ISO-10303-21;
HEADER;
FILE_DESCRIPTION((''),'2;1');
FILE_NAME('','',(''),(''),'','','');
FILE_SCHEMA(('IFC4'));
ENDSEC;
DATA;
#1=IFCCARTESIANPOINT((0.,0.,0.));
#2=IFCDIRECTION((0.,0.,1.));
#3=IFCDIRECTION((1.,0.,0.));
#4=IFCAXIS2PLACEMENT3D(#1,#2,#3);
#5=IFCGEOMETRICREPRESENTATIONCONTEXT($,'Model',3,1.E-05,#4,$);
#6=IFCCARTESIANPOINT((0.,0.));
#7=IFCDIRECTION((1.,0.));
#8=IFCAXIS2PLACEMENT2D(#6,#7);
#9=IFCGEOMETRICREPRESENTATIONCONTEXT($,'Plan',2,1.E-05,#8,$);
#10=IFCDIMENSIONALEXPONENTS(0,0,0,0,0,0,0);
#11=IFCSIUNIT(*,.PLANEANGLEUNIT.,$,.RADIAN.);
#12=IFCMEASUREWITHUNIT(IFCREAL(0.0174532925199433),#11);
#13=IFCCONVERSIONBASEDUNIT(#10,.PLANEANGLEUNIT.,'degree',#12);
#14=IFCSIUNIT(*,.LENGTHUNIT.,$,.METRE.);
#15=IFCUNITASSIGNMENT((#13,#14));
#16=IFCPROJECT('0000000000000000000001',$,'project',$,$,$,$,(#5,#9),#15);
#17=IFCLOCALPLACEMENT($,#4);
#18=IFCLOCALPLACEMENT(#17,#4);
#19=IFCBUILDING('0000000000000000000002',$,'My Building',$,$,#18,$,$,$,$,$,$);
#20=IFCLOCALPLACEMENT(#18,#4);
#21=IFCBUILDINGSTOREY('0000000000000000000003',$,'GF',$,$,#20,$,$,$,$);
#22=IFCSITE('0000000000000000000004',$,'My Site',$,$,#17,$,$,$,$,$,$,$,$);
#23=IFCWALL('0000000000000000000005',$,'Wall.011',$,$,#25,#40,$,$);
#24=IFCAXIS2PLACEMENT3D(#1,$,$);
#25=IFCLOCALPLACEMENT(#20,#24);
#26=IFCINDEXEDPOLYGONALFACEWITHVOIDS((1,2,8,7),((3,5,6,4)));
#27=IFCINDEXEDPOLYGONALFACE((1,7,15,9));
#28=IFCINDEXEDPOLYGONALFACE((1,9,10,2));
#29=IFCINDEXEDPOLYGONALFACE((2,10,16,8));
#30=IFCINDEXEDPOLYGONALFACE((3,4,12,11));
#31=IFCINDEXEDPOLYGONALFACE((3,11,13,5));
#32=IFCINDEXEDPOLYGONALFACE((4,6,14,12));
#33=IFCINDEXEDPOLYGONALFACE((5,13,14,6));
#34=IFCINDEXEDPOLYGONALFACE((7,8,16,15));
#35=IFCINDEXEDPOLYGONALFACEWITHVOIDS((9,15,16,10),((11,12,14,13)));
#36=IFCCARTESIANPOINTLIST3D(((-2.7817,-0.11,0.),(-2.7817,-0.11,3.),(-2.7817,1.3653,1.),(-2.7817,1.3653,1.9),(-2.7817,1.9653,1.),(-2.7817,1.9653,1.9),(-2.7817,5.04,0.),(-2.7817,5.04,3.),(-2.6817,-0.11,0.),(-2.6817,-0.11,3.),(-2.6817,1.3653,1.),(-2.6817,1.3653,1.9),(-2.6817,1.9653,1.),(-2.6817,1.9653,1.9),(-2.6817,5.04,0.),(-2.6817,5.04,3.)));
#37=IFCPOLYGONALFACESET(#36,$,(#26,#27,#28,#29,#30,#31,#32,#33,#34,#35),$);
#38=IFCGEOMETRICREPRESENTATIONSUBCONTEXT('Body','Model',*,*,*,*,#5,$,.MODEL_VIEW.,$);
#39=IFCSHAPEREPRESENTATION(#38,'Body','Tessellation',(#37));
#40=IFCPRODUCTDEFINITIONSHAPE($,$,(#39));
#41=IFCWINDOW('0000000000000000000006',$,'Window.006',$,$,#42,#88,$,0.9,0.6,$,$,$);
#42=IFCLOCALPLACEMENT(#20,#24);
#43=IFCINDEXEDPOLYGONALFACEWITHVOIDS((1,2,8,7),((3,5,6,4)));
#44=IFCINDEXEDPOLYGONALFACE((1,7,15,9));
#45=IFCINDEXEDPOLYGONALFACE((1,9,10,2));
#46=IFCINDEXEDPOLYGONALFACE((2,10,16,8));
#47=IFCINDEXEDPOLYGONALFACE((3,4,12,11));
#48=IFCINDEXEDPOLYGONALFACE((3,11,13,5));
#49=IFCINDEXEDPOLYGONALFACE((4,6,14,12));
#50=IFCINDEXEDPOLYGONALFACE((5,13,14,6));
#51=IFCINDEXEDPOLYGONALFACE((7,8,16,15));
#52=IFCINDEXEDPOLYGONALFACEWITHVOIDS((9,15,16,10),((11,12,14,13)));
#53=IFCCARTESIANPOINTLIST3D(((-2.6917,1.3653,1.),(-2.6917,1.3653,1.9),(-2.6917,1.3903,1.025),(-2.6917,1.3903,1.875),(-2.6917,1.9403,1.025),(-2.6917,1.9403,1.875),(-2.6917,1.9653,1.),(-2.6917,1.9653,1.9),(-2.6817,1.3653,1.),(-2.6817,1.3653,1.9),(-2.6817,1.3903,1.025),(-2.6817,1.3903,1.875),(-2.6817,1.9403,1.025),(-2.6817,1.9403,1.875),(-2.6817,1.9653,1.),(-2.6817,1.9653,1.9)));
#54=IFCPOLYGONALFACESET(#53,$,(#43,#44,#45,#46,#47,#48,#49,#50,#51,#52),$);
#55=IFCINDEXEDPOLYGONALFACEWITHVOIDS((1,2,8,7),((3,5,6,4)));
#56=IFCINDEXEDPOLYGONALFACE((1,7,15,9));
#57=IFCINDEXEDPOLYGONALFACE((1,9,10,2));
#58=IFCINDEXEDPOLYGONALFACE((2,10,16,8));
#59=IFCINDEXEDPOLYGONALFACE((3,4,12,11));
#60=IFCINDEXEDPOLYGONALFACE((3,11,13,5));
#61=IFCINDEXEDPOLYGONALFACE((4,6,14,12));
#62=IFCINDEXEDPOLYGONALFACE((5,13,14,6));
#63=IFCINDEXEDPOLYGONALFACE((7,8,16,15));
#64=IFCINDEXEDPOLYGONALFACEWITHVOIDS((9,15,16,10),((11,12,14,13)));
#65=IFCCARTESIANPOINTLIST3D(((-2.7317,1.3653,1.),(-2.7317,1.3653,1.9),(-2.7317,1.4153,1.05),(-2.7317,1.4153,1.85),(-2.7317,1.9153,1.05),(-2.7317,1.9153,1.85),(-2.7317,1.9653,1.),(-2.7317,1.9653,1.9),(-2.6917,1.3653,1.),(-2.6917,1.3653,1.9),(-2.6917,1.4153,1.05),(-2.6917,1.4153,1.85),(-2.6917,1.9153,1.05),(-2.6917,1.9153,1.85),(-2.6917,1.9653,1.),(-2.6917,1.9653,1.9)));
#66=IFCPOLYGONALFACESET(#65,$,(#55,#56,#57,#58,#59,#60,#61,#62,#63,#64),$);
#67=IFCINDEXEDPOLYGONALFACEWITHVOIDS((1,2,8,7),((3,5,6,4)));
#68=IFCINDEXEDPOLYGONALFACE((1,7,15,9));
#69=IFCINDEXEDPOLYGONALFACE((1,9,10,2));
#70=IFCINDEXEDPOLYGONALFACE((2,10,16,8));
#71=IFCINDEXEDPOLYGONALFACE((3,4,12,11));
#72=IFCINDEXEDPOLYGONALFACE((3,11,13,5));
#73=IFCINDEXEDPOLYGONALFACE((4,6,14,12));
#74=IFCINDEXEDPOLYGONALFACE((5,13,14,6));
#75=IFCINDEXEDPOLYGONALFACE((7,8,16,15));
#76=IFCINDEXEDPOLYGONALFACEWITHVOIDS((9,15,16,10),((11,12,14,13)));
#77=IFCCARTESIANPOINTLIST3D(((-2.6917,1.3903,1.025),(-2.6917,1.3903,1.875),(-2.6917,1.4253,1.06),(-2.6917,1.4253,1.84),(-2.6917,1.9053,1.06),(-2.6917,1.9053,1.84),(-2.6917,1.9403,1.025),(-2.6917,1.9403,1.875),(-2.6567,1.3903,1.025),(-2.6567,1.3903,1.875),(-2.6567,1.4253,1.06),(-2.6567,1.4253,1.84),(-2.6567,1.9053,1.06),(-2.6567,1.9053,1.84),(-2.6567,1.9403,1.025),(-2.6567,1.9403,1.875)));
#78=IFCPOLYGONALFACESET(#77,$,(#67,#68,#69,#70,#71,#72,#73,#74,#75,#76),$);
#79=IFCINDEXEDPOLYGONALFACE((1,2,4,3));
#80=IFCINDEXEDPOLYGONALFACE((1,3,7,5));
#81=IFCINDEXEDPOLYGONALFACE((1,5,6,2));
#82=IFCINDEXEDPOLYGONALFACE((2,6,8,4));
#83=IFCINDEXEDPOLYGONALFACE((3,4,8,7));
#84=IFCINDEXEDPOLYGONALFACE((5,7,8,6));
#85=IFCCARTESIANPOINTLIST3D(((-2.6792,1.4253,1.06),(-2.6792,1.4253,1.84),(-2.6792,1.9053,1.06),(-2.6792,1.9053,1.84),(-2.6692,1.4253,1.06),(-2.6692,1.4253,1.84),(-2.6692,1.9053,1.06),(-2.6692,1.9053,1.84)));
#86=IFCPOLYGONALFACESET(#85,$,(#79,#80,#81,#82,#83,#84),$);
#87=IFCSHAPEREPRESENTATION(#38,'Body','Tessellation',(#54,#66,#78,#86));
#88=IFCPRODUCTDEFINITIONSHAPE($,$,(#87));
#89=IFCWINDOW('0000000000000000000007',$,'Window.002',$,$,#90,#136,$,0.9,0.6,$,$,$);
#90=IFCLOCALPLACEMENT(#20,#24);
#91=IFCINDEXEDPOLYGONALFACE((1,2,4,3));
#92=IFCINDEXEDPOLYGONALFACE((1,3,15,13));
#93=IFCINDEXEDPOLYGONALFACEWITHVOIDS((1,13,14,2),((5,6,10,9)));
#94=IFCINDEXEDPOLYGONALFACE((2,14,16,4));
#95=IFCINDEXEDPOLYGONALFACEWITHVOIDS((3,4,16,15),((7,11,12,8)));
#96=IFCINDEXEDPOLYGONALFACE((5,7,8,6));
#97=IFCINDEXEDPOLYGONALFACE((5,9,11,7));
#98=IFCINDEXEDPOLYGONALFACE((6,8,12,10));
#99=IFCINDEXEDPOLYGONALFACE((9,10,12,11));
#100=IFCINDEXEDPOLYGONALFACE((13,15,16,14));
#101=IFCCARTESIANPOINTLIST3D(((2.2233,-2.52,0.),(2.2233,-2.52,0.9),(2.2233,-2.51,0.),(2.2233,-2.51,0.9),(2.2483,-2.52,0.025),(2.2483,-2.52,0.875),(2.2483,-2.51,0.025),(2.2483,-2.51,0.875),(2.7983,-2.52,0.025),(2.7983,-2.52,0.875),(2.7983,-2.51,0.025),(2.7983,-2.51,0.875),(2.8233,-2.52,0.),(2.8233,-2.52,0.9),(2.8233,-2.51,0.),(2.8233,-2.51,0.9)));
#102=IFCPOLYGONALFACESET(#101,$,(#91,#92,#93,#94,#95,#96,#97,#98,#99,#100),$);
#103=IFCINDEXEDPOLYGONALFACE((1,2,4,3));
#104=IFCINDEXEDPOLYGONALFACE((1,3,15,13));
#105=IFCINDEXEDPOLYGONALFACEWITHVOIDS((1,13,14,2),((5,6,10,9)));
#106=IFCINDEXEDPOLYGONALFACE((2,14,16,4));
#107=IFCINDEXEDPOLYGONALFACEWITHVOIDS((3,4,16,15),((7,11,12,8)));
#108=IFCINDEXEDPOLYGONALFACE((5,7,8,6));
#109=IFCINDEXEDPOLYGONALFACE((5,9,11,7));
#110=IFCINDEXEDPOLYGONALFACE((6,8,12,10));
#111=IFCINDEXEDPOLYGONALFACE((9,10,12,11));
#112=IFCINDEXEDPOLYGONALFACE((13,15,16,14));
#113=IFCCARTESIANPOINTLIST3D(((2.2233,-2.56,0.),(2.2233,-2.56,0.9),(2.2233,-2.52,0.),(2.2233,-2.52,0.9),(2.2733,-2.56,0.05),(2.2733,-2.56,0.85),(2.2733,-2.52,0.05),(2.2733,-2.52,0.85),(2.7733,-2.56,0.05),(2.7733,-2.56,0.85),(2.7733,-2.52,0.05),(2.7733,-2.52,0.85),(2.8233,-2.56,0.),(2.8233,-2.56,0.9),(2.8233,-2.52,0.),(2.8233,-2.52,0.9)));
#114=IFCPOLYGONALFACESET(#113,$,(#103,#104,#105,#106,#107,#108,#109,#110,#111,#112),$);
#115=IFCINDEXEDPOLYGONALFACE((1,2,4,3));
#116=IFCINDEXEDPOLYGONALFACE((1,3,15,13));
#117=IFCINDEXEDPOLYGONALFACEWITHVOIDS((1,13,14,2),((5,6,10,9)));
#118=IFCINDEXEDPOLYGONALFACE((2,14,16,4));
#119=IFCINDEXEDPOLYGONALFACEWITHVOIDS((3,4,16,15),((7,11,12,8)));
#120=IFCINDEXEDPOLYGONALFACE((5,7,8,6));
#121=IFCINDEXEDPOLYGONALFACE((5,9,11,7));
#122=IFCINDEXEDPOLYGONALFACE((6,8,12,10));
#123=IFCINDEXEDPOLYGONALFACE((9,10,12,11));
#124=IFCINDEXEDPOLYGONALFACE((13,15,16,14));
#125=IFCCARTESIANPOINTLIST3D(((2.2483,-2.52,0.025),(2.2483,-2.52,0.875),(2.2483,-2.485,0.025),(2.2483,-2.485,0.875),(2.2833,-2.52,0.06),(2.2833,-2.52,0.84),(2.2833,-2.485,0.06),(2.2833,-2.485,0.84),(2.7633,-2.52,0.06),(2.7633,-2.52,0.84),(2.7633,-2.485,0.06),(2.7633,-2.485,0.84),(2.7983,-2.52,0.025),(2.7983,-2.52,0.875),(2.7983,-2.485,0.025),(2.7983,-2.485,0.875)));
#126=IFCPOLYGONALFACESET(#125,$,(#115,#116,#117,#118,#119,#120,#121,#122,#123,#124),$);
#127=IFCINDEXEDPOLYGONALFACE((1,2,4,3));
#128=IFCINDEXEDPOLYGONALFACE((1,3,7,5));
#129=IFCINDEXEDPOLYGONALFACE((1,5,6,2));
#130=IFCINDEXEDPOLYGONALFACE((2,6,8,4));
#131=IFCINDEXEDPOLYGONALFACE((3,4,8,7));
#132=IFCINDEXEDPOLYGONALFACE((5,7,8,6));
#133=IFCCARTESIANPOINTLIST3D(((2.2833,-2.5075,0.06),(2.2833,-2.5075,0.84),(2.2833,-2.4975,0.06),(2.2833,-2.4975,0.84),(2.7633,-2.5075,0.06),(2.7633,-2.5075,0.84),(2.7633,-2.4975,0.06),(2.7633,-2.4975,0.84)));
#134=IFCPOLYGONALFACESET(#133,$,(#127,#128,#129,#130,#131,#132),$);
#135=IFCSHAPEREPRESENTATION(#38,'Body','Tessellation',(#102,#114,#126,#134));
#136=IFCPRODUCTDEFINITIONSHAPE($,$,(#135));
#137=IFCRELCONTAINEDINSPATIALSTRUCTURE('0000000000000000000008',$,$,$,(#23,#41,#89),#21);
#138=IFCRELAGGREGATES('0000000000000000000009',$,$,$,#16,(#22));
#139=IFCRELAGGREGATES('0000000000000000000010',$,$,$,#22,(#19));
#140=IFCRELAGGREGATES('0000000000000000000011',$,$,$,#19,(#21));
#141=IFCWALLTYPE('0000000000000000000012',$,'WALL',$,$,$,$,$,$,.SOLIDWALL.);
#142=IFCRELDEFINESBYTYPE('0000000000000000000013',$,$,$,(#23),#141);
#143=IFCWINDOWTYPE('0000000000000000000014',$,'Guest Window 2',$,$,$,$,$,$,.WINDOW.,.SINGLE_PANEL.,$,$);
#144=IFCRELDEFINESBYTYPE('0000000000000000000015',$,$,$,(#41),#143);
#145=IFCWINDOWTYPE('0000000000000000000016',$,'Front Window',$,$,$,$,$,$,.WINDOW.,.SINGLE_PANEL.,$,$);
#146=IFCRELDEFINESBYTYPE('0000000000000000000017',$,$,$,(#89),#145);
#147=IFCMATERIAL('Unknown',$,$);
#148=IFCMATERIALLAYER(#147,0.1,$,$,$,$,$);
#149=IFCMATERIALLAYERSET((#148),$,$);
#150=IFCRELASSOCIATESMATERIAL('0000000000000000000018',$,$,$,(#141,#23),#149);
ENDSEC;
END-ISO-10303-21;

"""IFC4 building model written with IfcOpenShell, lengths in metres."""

from ifc_helpers import new_model, entity, si_unit, converted_unit, frame, origin_with_axes, origin_2d_with_axis, place, context, subcontext, project, spatial, line, indexed_curve, outline, extrude, shape, source, transform, mapped, material, layer, layer_set, layer_usage, type_object, type_shapes, element, fill, save


model = new_model("IFC4")

# Units and contexts
model_context = context("Model", 3, precision=1e-05, world=origin_with_axes())
plan_context = context("Plan", 2, precision=1e-05, world=origin_2d_with_axis())
body_context_1 = subcontext(model_context, "Body", "Model", "MODEL_VIEW")
body_context_2 = subcontext(plan_context, "Body", "Plan", "PLAN_VIEW")
ifc_project = project(units=[converted_unit("PLANEANGLEUNIT", "degree", entity("IfcReal", 0.0174532925199433), si_unit("PLANEANGLEUNIT", "RADIAN"), dimensions=[0, 0, 0, 0, 0, 0, 0]), si_unit("LENGTHUNIT", "METRE")], contexts=[model_context, plan_context])

# Site, building, storey
site_placement = place(None, origin_with_axes())
site = spatial("IfcSite", under=ifc_project, at=site_placement, Name="My Site")
building_placement = place(site_placement, origin_with_axes())
building = spatial("IfcBuilding", under=site, at=building_placement, Name="My Building")
storey_placement = place(building_placement, origin_with_axes())
storey = spatial("IfcBuildingStorey", under=building, at=storey_placement, Name="GF")

# Shared definitions
ifc_material = material(Name="Unknown")
ifc_layer = layer(ifc_material, 0.1)
ifc_layer_set = layer_set([ifc_layer])
wall_type = type_object("IfcWallType", Name="WALL", PredefinedType="SOLIDWALL", material=ifc_layer_set)
window_type_1 = type_object("IfcWindowType", Name="Front Window", PartitioningType="SINGLE_PANEL", PredefinedType="WINDOW")
shared_shape_1 = source(origin_with_axes(), body_context_1, "Body", "SweptSolid", [
    extrude(outline(indexed_curve([(0.0, 0.0), (0.6, 0.0), (0.6, 0.9), (0.0, 0.9)], segments=[line(1, 2, 3, 4, 1)]), holes=[indexed_curve([(0.025, 0.025), (0.575, 0.025), (0.575, 0.875), (0.025, 0.875)], segments=[line(1, 2, 3, 4, 1)])]), frame((0.0, 0.09, 0.0), z_axis=(0.0, -1.0, 0.0), x_axis=(1.0, 0.0, 0.0)), (0.0, 0.0, -1.0), 0.01),
    extrude(outline(indexed_curve([(0.0, 0.0), (0.6, 0.0), (0.6, 0.9), (0.0, 0.9)], segments=[line(1, 2, 3, 4, 1)]), holes=[indexed_curve([(0.05, 0.05), (0.55, 0.05), (0.55, 0.85), (0.05, 0.85)], segments=[line(1, 2, 3, 4, 1)])]), frame((0.0, 0.05, 0.0), z_axis=(0.0, -1.0, 0.0), x_axis=(1.0, 0.0, 0.0)), (0.0, 0.0, -1.0), 0.04),
    extrude(outline(indexed_curve([(0.0, 0.0), (0.55, 0.0), (0.55, 0.85), (0.0, 0.85)], segments=[line(1, 2, 3, 4, 1)]), holes=[indexed_curve([(0.035, 0.035), (0.515, 0.035), (0.515, 0.815), (0.035, 0.815)], segments=[line(1, 2, 3, 4, 1)])]), frame((0.025, 0.09, 0.025), z_axis=(0.0, -1.0, 0.0), x_axis=(1.0, 0.0, 0.0)), (0.0, 0.0, -1.0), 0.035),
    extrude(outline(indexed_curve([(0.035, 0.035), (0.515, 0.035), (0.515, 0.815), (0.035, 0.815)], segments=[line(1, 2, 3, 4, 1)])), frame((0.025, 0.1025, 0.025), z_axis=(0.0, -1.0, 0.0), x_axis=(1.0, 0.0, 0.0)), (0.0, 0.0, -1.0), 0.01),
])
shared_shape_2 = source(origin_with_axes(), body_context_2, "Body", "Curve2D", [
    entity("IfcIndexedPolyCurve", entity("IfcCartesianPointList2D", [[0.05, 0.05], [0.55, 0.05]])),
    entity("IfcIndexedPolyCurve", entity("IfcCartesianPointList2D", [[0.0, 0.1], [0.025, 0.1], [0.025, 0.09], [0.05, 0.09], [0.05, 0.05], [0.0, 0.05]]), [entity("IfcLineIndex", [1, 2, 3, 4, 5, 6, 1])]),
    entity("IfcIndexedPolyCurve", entity("IfcCartesianPointList2D", [[0.6, 0.1], [0.575, 0.1], [0.575, 0.09], [0.55, 0.09], [0.55, 0.05], [0.6, 0.05]]), [entity("IfcLineIndex", [1, 2, 3, 4, 5, 6, 1])]),
    entity("IfcIndexedPolyCurve", entity("IfcCartesianPointList2D", [[0.025, 0.09], [0.06, 0.09], [0.06, 0.125], [0.025, 0.125]]), [entity("IfcLineIndex", [1, 2, 3, 4, 1])]),
    entity("IfcIndexedPolyCurve", entity("IfcCartesianPointList2D", [[0.575, 0.09], [0.54, 0.09], [0.54, 0.125], [0.575, 0.125]]), [entity("IfcLineIndex", [1, 2, 3, 4, 1])]),
    entity("IfcIndexedPolyCurve", entity("IfcCartesianPointList2D", [[0.06, 0.09], [0.54, 0.09]])),
    entity("IfcIndexedPolyCurve", entity("IfcCartesianPointList2D", [[0.06, 0.125], [0.54, 0.125]])),
    entity("IfcIndexedPolyCurve", entity("IfcCartesianPointList2D", [[0.06, 0.1075], [0.54, 0.1075]])),
])
type_shapes(window_type_1, [shared_shape_1, shared_shape_2])

# Wall, opening, window
ifc_layer_usage_1 = layer_usage(ifc_layer_set, "AXIS2", "POSITIVE", 0.0)
wall_1_placement = place(storey_placement, frame((-2.7817, 5.04, 0.0), z_axis=(0.0, 0.0, 1.0), x_axis=(0.0, -1.0, 0.0)))
wall_1 = element("IfcWall", 1, at=wall_1_placement, inside=storey, type_object=wall_type, material=ifc_layer_usage_1, Name="Wall.011", context=body_context_1, shape_type="SweptSolid", body=[
    extrude(outline(indexed_curve([(0.0, 0.0), (0.0, 0.1), (5.15, 0.1), (5.15, 0.0)], segments=[line(1, 2, 3, 4, 1)])), origin_with_axes(), (0.0, 0.0, 1.0), 3.0),
])
shared_shape_3 = source(origin_with_axes(), body_context_1, "Body", "SweptSolid", [
    extrude(outline(indexed_curve([(0.0, 0.0), (0.6, 0.0), (0.6, 0.9), (0.0, 0.9)], segments=[line(1, 2, 3, 4, 1)])), frame((0.0, -0.6, 0.0), z_axis=(0.0, -1.0, 0.0), x_axis=(1.0, 0.0, 0.0)), (0.0, 0.0, -1.0), 1.2),
])
opening_1_placement = place(wall_1_placement, frame((3.0746, 0.0, 1.0), z_axis=(0.0, 0.0, 1.0), x_axis=(1.0, 0.0, 0.0)))
opening_1 = element("IfcOpeningElement", 2, at=opening_1_placement, cuts=wall_1, PredefinedType="OPENING", context=body_context_1, shape_type="MappedRepresentation", body=[
    mapped(shared_shape_3, transform((0.0, 0.0, 0.0), x_axis=(1.0, 0.0, 0.0), y_axis=(0.0, 1.0, 0.0), z_axis=(0.0, 0.0, 1.0), scale=1.0)),
])
window_type_2 = type_object("IfcWindowType", Name="Guest Window 2", PartitioningType="SINGLE_PANEL", PredefinedType="WINDOW")
shared_shape_4 = source(origin_with_axes(), body_context_1, "Body", "SweptSolid", [
    extrude(outline(indexed_curve([(0.0, 0.0), (0.6, 0.0), (0.6, 0.9), (0.0, 0.9)], segments=[line(1, 2, 3, 4, 1)]), holes=[indexed_curve([(0.025, 0.025), (0.575, 0.025), (0.575, 0.875), (0.025, 0.875)], segments=[line(1, 2, 3, 4, 1)])]), frame((0.0, 0.09, 0.0), z_axis=(0.0, -1.0, 0.0), x_axis=(1.0, 0.0, 0.0)), (0.0, 0.0, -1.0), 0.01),
    extrude(outline(indexed_curve([(0.0, 0.0), (0.6, 0.0), (0.6, 0.9), (0.0, 0.9)], segments=[line(1, 2, 3, 4, 1)]), holes=[indexed_curve([(0.05, 0.05), (0.55, 0.05), (0.55, 0.85), (0.05, 0.85)], segments=[line(1, 2, 3, 4, 1)])]), frame((0.0, 0.05, 0.0), z_axis=(0.0, -1.0, 0.0), x_axis=(1.0, 0.0, 0.0)), (0.0, 0.0, -1.0), 0.04),
    extrude(outline(indexed_curve([(0.0, 0.0), (0.55, 0.0), (0.55, 0.85), (0.0, 0.85)], segments=[line(1, 2, 3, 4, 1)]), holes=[indexed_curve([(0.035, 0.035), (0.515, 0.035), (0.515, 0.815), (0.035, 0.815)], segments=[line(1, 2, 3, 4, 1)])]), frame((0.025, 0.09, 0.025), z_axis=(0.0, -1.0, 0.0), x_axis=(1.0, 0.0, 0.0)), (0.0, 0.0, -1.0), 0.035),
    extrude(outline(indexed_curve([(0.035, 0.035), (0.515, 0.035), (0.515, 0.815), (0.035, 0.815)], segments=[line(1, 2, 3, 4, 1)])), frame((0.025, 0.1025, 0.025), z_axis=(0.0, -1.0, 0.0), x_axis=(1.0, 0.0, 0.0)), (0.0, 0.0, -1.0), 0.01),
])
shared_shape_5 = source(origin_with_axes(), body_context_2, "Body", "Curve2D", [
    entity("IfcIndexedPolyCurve", entity("IfcCartesianPointList2D", [[0.05, 0.05], [0.55, 0.05]])),
    entity("IfcIndexedPolyCurve", entity("IfcCartesianPointList2D", [[0.0, 0.1], [0.025, 0.1], [0.025, 0.09], [0.05, 0.09], [0.05, 0.05], [0.0, 0.05]]), [entity("IfcLineIndex", [1, 2, 3, 4, 5, 6, 1])]),
    entity("IfcIndexedPolyCurve", entity("IfcCartesianPointList2D", [[0.6, 0.1], [0.575, 0.1], [0.575, 0.09], [0.55, 0.09], [0.55, 0.05], [0.6, 0.05]]), [entity("IfcLineIndex", [1, 2, 3, 4, 5, 6, 1])]),
    entity("IfcIndexedPolyCurve", entity("IfcCartesianPointList2D", [[0.025, 0.09], [0.06, 0.09], [0.06, 0.125], [0.025, 0.125]]), [entity("IfcLineIndex", [1, 2, 3, 4, 1])]),
    entity("IfcIndexedPolyCurve", entity("IfcCartesianPointList2D", [[0.575, 0.09], [0.54, 0.09], [0.54, 0.125], [0.575, 0.125]]), [entity("IfcLineIndex", [1, 2, 3, 4, 1])]),
    entity("IfcIndexedPolyCurve", entity("IfcCartesianPointList2D", [[0.06, 0.09], [0.54, 0.09]])),
    entity("IfcIndexedPolyCurve", entity("IfcCartesianPointList2D", [[0.06, 0.125], [0.54, 0.125]])),
    entity("IfcIndexedPolyCurve", entity("IfcCartesianPointList2D", [[0.06, 0.1075], [0.54, 0.1075]])),
])
type_shapes(window_type_2, [shared_shape_4, shared_shape_5])
window_1_placement = place(opening_1_placement, frame((0.0, 0.0, 0.0), z_axis=(0.0, 0.0, 1.0), x_axis=(1.0, 0.0, 0.0)))
window_1 = element("IfcWindow", 3, at=window_1_placement, inside=storey, type_object=window_type_2, Name="Window.006", OverallHeight=0.9, OverallWidth=0.6, shapes=[
    shape(body_context_1, "Body", "MappedRepresentation", [mapped(shared_shape_4, transform((0.0, 0.0, 0.0), x_axis=(1.0, 0.0, 0.0), y_axis=(0.0, 1.0, 0.0), z_axis=(0.0, 0.0, 1.0), scale=1.0))]),
    shape(body_context_2, "Body", "MappedRepresentation", [mapped(shared_shape_5, transform((0.0, 0.0, 0.0), x_axis=(1.0, 0.0, 0.0), y_axis=(0.0, 1.0, 0.0), z_axis=(0.0, 0.0, 1.0), scale=1.0))]),
])
fill(opening_1, window_1)

# Window
for number, where, z_axis, x_axis, name in (
    (4, (2.2233, -2.61, 0.0), (0.0, 0.0, 1.0), (1.0, 0.0, 0.0), "Window.002"),
):
    element("IfcWindow", number, at=place(storey_placement, frame(where, z_axis=z_axis, x_axis=x_axis)), inside=storey, type_object=window_type_1, Name=name, OverallHeight=0.9, OverallWidth=0.6, shapes=[
        shape(body_context_1, "Body", "MappedRepresentation", [mapped(shared_shape_1, transform((0.0, 0.0, 0.0), x_axis=(1.0, 0.0, 0.0), y_axis=(0.0, 1.0, 0.0), z_axis=(0.0, 0.0, 1.0), scale=1.0))]),
        shape(body_context_2, "Body", "MappedRepresentation", [mapped(shared_shape_2, transform((0.0, 0.0, 0.0), x_axis=(1.0, 0.0, 0.0), y_axis=(0.0, 1.0, 0.0), z_axis=(0.0, 0.0, 1.0), scale=1.0))]),
    ])

save(model, "model.ifc")
